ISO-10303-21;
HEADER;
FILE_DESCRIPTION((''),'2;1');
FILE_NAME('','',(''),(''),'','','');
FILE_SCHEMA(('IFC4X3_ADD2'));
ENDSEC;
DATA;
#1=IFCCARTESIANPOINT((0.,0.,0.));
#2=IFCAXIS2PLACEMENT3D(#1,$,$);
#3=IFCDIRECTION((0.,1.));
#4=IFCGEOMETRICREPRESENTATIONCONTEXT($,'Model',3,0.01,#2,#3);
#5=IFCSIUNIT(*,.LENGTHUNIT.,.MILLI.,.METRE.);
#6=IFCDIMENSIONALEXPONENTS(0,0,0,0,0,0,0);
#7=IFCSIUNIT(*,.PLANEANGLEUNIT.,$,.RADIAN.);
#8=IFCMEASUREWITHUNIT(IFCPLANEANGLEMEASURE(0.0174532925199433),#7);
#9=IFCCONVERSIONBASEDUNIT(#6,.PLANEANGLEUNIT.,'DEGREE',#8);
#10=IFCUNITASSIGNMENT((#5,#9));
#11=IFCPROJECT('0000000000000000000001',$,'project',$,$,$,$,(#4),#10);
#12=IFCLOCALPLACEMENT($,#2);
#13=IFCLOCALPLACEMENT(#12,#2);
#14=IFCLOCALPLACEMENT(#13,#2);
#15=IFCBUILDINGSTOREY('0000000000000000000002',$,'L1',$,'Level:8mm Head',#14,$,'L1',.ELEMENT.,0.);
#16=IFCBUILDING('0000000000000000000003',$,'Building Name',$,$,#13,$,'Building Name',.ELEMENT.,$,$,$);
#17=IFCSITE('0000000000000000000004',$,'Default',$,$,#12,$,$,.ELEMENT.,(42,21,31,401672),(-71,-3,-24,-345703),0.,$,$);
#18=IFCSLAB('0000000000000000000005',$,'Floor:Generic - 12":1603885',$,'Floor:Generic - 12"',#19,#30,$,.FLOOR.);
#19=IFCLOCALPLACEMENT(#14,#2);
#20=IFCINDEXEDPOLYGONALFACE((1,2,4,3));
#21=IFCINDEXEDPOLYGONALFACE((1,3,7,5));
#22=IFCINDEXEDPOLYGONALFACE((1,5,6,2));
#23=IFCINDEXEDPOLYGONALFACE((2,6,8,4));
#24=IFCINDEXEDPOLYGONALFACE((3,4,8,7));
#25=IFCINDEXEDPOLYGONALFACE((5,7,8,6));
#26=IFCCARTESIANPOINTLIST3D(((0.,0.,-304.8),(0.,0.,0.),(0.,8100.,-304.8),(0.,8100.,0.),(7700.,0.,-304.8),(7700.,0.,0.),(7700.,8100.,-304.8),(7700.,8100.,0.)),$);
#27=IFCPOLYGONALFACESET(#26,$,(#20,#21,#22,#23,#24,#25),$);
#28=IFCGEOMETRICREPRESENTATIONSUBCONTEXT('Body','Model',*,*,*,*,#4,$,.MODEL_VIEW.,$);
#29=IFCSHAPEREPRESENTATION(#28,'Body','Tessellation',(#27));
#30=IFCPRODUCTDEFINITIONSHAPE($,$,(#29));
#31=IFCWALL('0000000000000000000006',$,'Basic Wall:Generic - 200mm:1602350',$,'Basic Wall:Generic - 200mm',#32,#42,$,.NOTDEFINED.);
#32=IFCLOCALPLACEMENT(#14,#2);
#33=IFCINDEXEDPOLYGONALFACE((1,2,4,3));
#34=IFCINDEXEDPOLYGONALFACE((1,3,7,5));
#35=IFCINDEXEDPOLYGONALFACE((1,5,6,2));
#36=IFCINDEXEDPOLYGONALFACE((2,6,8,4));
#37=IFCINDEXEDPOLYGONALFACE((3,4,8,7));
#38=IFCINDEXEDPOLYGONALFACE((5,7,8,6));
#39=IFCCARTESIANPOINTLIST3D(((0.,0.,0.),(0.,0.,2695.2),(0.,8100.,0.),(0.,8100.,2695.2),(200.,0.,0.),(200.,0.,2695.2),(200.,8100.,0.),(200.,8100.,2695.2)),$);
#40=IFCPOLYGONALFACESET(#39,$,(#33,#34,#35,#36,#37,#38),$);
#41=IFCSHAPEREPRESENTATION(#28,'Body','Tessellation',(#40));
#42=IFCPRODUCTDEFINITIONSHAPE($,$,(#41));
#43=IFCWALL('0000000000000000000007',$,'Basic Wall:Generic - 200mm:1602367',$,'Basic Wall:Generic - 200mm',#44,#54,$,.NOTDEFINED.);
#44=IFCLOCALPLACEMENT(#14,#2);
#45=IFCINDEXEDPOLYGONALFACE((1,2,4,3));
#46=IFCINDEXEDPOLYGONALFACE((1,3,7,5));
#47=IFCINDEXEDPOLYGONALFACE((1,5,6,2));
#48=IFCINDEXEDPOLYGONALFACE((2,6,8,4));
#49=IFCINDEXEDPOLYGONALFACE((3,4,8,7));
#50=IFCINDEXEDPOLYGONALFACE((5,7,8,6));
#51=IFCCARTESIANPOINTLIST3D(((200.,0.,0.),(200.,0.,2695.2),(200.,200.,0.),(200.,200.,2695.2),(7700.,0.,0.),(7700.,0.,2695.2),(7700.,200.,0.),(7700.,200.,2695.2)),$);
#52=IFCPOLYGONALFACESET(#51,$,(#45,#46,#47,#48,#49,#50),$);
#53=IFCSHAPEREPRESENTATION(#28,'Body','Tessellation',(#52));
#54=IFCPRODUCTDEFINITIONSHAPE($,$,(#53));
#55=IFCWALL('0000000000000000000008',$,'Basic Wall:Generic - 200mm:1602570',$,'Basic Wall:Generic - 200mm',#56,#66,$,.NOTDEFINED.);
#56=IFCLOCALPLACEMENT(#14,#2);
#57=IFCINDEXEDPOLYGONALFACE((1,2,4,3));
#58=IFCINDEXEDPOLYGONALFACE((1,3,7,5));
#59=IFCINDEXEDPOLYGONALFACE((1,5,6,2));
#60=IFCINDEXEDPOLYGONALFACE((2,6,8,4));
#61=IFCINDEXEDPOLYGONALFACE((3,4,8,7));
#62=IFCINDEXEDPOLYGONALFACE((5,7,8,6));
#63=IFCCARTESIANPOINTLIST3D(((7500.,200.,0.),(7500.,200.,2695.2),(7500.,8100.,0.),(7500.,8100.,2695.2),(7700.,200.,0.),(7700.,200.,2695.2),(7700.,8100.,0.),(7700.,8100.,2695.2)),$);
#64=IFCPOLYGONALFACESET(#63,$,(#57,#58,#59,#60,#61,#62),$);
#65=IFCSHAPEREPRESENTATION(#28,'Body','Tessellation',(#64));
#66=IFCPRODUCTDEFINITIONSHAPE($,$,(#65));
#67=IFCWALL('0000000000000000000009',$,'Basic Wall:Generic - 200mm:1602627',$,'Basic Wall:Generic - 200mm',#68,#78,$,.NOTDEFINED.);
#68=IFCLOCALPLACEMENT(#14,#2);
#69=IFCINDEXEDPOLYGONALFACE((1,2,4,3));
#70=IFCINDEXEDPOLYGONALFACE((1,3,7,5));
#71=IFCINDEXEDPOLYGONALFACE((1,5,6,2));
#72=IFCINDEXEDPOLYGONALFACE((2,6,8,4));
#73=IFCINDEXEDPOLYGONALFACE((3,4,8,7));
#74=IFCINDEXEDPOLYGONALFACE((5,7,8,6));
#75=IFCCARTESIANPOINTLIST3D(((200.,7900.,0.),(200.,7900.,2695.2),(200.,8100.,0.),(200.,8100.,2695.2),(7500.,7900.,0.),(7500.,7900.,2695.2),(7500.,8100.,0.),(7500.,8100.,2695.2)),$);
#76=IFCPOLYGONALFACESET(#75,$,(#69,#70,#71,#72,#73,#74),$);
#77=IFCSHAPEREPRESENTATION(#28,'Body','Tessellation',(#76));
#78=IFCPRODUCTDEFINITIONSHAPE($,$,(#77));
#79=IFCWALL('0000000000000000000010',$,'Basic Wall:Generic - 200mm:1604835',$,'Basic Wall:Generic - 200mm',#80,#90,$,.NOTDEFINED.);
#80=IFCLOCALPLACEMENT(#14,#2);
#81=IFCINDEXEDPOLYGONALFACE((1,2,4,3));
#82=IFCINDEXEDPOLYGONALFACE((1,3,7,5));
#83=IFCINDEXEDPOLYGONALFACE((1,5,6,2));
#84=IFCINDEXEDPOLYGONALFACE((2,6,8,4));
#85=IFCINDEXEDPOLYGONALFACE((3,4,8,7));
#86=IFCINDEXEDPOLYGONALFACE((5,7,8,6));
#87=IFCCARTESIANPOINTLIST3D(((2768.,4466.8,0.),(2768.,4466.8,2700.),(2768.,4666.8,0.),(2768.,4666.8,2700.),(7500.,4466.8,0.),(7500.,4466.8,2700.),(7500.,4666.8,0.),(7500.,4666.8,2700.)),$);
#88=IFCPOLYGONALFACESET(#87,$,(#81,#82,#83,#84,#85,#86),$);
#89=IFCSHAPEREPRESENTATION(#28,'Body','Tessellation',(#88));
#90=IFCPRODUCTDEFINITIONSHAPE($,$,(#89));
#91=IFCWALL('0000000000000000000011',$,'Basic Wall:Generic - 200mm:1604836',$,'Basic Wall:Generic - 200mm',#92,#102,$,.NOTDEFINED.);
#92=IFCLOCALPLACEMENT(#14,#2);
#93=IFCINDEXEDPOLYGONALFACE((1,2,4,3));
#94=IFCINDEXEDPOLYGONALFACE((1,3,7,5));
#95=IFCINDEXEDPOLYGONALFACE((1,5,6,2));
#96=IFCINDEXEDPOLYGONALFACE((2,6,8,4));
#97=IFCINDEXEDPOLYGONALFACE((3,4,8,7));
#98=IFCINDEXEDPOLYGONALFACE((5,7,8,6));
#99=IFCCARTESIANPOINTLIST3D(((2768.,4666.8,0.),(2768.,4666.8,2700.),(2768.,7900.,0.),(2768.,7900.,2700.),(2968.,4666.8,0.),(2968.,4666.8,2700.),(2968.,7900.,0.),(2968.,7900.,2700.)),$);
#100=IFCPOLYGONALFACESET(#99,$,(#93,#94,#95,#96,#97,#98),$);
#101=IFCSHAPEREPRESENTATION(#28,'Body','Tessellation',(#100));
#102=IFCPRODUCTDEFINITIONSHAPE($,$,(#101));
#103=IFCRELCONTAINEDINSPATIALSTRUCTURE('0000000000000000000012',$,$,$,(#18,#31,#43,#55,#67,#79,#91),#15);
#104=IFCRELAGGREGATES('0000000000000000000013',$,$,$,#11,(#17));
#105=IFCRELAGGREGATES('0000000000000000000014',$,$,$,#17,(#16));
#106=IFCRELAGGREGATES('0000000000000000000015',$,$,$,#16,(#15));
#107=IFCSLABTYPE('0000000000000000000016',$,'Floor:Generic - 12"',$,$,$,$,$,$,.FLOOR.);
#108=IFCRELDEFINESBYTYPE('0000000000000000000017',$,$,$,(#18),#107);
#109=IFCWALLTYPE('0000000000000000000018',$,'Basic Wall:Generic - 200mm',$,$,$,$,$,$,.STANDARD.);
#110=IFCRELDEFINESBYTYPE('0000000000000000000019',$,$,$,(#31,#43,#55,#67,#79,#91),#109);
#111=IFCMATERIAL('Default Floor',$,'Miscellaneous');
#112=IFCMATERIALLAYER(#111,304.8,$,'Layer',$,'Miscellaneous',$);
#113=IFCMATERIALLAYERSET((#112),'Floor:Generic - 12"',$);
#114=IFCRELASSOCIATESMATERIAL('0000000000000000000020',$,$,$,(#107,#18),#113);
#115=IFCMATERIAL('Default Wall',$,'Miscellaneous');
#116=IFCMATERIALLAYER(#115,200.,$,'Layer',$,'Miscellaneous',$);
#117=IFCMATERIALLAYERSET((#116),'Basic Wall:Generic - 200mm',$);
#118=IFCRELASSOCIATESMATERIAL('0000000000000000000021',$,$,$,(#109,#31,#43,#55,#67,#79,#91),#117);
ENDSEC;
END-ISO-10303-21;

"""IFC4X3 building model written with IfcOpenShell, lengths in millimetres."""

from ifc_helpers import new_model, entity, si_unit, converted_unit, direction, frame, frame_2d, origin, origin_2d_with_axis, place, context, subcontext, project, spatial, polyline, rectangle, extrude, clip, bounded_halfspace, material, layer, layer_set, layer_usage, type_object, element, save


model = new_model("IFC4X3")

# Units and contexts
model_context = context("Model", 3, precision=0.01, world=origin(), true_north=direction((0.0, 1.0)))
body_context = subcontext(model_context, "Body", "Model", "MODEL_VIEW")
ifc_project = project(units=[si_unit("LENGTHUNIT", "METRE", prefix="MILLI"), converted_unit("PLANEANGLEUNIT", "DEGREE", entity("IfcPlaneAngleMeasure", 0.0174532925199433), si_unit("PLANEANGLEUNIT", "RADIAN"), dimensions=[0, 0, 0, 0, 0, 0, 0])], contexts=[model_context])

# Site, building, storey
site_placement = place(None, origin())
site = spatial("IfcSite", under=ifc_project, at=site_placement, Name="Default", CompositionType="ELEMENT", RefLatitude=(42, 21, 31, 401672), RefLongitude=(-71, -3, -24, -345703), RefElevation=0.0)
building_placement = place(site_placement, origin())
building = spatial("IfcBuilding", under=site, at=building_placement, Name="Building Name", LongName="Building Name", CompositionType="ELEMENT")
storey_placement = place(building_placement, origin())
storey = spatial("IfcBuildingStorey", under=building, at=storey_placement, Name="L1", ObjectType="Level:8mm Head", LongName="L1", CompositionType="ELEMENT", Elevation=0.0)

# Slab
ifc_material_1 = material(Name="Default Floor", Category="Miscellaneous")
ifc_layer_1 = layer(ifc_material_1, 304.8, Name="Layer", Category="Miscellaneous")
ifc_layer_set_1 = layer_set([ifc_layer_1], Name="Floor:Generic - 12\"")
ifc_layer_usage = layer_usage(ifc_layer_set_1, "AXIS3", "POSITIVE", 0.0)
slab_type = type_object("IfcSlabType", Name="Floor:Generic - 12\"", PredefinedType="FLOOR", material=ifc_layer_set_1)
slab_placement = place(storey_placement, origin())
element("IfcSlab", 1, at=slab_placement, inside=storey, type_object=slab_type, material=ifc_layer_usage, Name="Floor:Generic - 12\":1603885", ObjectType="Floor:Generic - 12\"", PredefinedType="FLOOR", context=body_context, shape_type="SweptSolid", body=[
    extrude(rectangle(XDim=8100.0, YDim=7700.0, at=origin_2d_with_axis()), frame((3850.0, 4050.0, 0.0), z_axis=(0.0, 0.0, -1.0), x_axis=(0.0, 1.0, 0.0)), (0.0, 0.0, 1.0), 304.8),
])

# Walls
ifc_material_2 = material(Name="Default Wall", Category="Miscellaneous")
ifc_layer_2 = layer(ifc_material_2, 200.0, Name="Layer", Category="Miscellaneous")
ifc_layer_set_2 = layer_set([ifc_layer_2], Name="Basic Wall:Generic - 200mm")
wall_type = type_object("IfcWallType", Name="Basic Wall:Generic - 200mm", PredefinedType="STANDARD", material=ifc_layer_set_2)
wall_1_placement = place(storey_placement, frame((100.0, 8100.0, 0.0), z_axis=(0.0, 0.0, 1.0), x_axis=(0.0, -1.0, 0.0)))
element("IfcWall", 2, at=wall_1_placement, inside=storey, type_object=wall_type, material=ifc_layer_set_2, Name="Basic Wall:Generic - 200mm:1602350", ObjectType="Basic Wall:Generic - 200mm", PredefinedType="NOTDEFINED", context=body_context, shape_type="Clipping", body=[
    clip(extrude(rectangle(XDim=8100.0, YDim=200.0, at=frame_2d((4050.0, 0.0), x_axis=(-1.0, 0.0))), origin(), (0.0, 0.0, 1.0), 2695.2), bounded_halfspace(frame((0.0, -100.0, 2695.2), z_axis=(0.0, 0.0, -1.0), x_axis=(0.0, 1.0, 0.0)), True, frame((0.0, -100.0, 2695.2)), polyline([(0.0, 0.0), (8100.0, 0.0), (8100.0, 200.0), (7900.0, 200.0), (200.0, 200.0), (0.0, 200.0), (0.0, 0.0)]))),
])
wall_2_placement = place(storey_placement, frame((200.0, 100.0, 0.0)))
element("IfcWall", 3, at=wall_2_placement, inside=storey, type_object=wall_type, material=ifc_layer_set_2, Name="Basic Wall:Generic - 200mm:1602367", ObjectType="Basic Wall:Generic - 200mm", PredefinedType="NOTDEFINED", context=body_context, shape_type="Clipping", body=[
    clip(extrude(rectangle(XDim=7500.0, YDim=200.0, at=frame_2d((3750.0, 0.0), x_axis=(-1.0, 0.0))), origin(), (0.0, 0.0, 1.0), 2695.2), bounded_halfspace(frame((0.0, -100.0, 2695.2), z_axis=(0.0, 0.0, -1.0), x_axis=(1.0, 0.0, 0.0)), True, frame((0.0, -100.0, 2695.2)), polyline([(0.0, 0.0), (7500.0, 0.0), (7500.0, 200.0), (7300.0, 200.0), (0.0, 200.0), (0.0, 0.0)]))),
])
wall_3_placement = place(storey_placement, frame((7600.0, 200.0, 0.0), z_axis=(0.0, 0.0, 1.0), x_axis=(0.0, 1.0, 0.0)))
element("IfcWall", 4, at=wall_3_placement, inside=storey, type_object=wall_type, material=ifc_layer_set_2, Name="Basic Wall:Generic - 200mm:1602570", ObjectType="Basic Wall:Generic - 200mm", PredefinedType="NOTDEFINED", context=body_context, shape_type="Clipping", body=[
    clip(extrude(rectangle(XDim=7900.0, YDim=200.0, at=frame_2d((3950.0, 0.0), x_axis=(-1.0, 0.0))), origin(), (0.0, 0.0, 1.0), 2695.2), bounded_halfspace(frame((0.0, -100.0, 2695.2), z_axis=(0.0, 0.0, -1.0), x_axis=(0.0, -1.0, 0.0)), True, frame((0.0, -100.0, 2695.2)), polyline([(0.0, 0.0), (7900.0, 0.0), (7900.0, 200.0), (7700.0, 200.0), (0.0, 200.0), (0.0, 0.0)]))),
])
wall_4_placement = place(storey_placement, frame((7500.0, 8000.0, 0.0), z_axis=(0.0, 0.0, 1.0), x_axis=(-1.0, 0.0, 0.0)))
element("IfcWall", 5, at=wall_4_placement, inside=storey, type_object=wall_type, material=ifc_layer_set_2, Name="Basic Wall:Generic - 200mm:1602627", ObjectType="Basic Wall:Generic - 200mm", PredefinedType="NOTDEFINED", context=body_context, shape_type="Clipping", body=[
    clip(extrude(rectangle(XDim=7300.0, YDim=200.0, at=frame_2d((3650.0, 0.0), x_axis=(-1.0, 0.0))), origin(), (0.0, 0.0, 1.0), 2695.2), bounded_halfspace(frame((0.0, -100.0, 2695.2), z_axis=(0.0, 0.0, -1.0), x_axis=(-1.0, 0.0, 0.0)), True, frame((0.0, -100.0, 2695.2)), polyline([(0.0, 0.0), (7300.0, 0.0), (7300.0, 200.0), (0.0, 200.0), (0.0, 0.0)]))),
])
wall_5_placement = place(storey_placement, frame((7500.0, 4566.8, 0.0), z_axis=(0.0, 0.0, 1.0), x_axis=(-1.0, 0.0, 0.0)))
element("IfcWall", 6, at=wall_5_placement, inside=storey, type_object=wall_type, material=ifc_layer_set_2, Name="Basic Wall:Generic - 200mm:1604835", ObjectType="Basic Wall:Generic - 200mm", PredefinedType="NOTDEFINED", context=body_context, shape_type="SweptSolid", body=[
    extrude(rectangle(XDim=4732.0, YDim=200.0, at=frame_2d((2366.0, 0.0), x_axis=(-1.0, 0.0))), origin(), (0.0, 0.0, 1.0), 2700.0),
])
wall_6_placement = place(storey_placement, frame((2868.0, 4666.8, 0.0), z_axis=(0.0, 0.0, 1.0), x_axis=(0.0, 1.0, 0.0)))
element("IfcWall", 7, at=wall_6_placement, inside=storey, type_object=wall_type, material=ifc_layer_set_2, Name="Basic Wall:Generic - 200mm:1604836", ObjectType="Basic Wall:Generic - 200mm", PredefinedType="NOTDEFINED", context=body_context, shape_type="SweptSolid", body=[
    extrude(rectangle(XDim=3233.2, YDim=200.0, at=frame_2d((1616.6, 0.0), x_axis=(-1.0, 0.0))), origin(), (0.0, 0.0, 1.0), 2700.0),
])

save(model, "model.ifc")
